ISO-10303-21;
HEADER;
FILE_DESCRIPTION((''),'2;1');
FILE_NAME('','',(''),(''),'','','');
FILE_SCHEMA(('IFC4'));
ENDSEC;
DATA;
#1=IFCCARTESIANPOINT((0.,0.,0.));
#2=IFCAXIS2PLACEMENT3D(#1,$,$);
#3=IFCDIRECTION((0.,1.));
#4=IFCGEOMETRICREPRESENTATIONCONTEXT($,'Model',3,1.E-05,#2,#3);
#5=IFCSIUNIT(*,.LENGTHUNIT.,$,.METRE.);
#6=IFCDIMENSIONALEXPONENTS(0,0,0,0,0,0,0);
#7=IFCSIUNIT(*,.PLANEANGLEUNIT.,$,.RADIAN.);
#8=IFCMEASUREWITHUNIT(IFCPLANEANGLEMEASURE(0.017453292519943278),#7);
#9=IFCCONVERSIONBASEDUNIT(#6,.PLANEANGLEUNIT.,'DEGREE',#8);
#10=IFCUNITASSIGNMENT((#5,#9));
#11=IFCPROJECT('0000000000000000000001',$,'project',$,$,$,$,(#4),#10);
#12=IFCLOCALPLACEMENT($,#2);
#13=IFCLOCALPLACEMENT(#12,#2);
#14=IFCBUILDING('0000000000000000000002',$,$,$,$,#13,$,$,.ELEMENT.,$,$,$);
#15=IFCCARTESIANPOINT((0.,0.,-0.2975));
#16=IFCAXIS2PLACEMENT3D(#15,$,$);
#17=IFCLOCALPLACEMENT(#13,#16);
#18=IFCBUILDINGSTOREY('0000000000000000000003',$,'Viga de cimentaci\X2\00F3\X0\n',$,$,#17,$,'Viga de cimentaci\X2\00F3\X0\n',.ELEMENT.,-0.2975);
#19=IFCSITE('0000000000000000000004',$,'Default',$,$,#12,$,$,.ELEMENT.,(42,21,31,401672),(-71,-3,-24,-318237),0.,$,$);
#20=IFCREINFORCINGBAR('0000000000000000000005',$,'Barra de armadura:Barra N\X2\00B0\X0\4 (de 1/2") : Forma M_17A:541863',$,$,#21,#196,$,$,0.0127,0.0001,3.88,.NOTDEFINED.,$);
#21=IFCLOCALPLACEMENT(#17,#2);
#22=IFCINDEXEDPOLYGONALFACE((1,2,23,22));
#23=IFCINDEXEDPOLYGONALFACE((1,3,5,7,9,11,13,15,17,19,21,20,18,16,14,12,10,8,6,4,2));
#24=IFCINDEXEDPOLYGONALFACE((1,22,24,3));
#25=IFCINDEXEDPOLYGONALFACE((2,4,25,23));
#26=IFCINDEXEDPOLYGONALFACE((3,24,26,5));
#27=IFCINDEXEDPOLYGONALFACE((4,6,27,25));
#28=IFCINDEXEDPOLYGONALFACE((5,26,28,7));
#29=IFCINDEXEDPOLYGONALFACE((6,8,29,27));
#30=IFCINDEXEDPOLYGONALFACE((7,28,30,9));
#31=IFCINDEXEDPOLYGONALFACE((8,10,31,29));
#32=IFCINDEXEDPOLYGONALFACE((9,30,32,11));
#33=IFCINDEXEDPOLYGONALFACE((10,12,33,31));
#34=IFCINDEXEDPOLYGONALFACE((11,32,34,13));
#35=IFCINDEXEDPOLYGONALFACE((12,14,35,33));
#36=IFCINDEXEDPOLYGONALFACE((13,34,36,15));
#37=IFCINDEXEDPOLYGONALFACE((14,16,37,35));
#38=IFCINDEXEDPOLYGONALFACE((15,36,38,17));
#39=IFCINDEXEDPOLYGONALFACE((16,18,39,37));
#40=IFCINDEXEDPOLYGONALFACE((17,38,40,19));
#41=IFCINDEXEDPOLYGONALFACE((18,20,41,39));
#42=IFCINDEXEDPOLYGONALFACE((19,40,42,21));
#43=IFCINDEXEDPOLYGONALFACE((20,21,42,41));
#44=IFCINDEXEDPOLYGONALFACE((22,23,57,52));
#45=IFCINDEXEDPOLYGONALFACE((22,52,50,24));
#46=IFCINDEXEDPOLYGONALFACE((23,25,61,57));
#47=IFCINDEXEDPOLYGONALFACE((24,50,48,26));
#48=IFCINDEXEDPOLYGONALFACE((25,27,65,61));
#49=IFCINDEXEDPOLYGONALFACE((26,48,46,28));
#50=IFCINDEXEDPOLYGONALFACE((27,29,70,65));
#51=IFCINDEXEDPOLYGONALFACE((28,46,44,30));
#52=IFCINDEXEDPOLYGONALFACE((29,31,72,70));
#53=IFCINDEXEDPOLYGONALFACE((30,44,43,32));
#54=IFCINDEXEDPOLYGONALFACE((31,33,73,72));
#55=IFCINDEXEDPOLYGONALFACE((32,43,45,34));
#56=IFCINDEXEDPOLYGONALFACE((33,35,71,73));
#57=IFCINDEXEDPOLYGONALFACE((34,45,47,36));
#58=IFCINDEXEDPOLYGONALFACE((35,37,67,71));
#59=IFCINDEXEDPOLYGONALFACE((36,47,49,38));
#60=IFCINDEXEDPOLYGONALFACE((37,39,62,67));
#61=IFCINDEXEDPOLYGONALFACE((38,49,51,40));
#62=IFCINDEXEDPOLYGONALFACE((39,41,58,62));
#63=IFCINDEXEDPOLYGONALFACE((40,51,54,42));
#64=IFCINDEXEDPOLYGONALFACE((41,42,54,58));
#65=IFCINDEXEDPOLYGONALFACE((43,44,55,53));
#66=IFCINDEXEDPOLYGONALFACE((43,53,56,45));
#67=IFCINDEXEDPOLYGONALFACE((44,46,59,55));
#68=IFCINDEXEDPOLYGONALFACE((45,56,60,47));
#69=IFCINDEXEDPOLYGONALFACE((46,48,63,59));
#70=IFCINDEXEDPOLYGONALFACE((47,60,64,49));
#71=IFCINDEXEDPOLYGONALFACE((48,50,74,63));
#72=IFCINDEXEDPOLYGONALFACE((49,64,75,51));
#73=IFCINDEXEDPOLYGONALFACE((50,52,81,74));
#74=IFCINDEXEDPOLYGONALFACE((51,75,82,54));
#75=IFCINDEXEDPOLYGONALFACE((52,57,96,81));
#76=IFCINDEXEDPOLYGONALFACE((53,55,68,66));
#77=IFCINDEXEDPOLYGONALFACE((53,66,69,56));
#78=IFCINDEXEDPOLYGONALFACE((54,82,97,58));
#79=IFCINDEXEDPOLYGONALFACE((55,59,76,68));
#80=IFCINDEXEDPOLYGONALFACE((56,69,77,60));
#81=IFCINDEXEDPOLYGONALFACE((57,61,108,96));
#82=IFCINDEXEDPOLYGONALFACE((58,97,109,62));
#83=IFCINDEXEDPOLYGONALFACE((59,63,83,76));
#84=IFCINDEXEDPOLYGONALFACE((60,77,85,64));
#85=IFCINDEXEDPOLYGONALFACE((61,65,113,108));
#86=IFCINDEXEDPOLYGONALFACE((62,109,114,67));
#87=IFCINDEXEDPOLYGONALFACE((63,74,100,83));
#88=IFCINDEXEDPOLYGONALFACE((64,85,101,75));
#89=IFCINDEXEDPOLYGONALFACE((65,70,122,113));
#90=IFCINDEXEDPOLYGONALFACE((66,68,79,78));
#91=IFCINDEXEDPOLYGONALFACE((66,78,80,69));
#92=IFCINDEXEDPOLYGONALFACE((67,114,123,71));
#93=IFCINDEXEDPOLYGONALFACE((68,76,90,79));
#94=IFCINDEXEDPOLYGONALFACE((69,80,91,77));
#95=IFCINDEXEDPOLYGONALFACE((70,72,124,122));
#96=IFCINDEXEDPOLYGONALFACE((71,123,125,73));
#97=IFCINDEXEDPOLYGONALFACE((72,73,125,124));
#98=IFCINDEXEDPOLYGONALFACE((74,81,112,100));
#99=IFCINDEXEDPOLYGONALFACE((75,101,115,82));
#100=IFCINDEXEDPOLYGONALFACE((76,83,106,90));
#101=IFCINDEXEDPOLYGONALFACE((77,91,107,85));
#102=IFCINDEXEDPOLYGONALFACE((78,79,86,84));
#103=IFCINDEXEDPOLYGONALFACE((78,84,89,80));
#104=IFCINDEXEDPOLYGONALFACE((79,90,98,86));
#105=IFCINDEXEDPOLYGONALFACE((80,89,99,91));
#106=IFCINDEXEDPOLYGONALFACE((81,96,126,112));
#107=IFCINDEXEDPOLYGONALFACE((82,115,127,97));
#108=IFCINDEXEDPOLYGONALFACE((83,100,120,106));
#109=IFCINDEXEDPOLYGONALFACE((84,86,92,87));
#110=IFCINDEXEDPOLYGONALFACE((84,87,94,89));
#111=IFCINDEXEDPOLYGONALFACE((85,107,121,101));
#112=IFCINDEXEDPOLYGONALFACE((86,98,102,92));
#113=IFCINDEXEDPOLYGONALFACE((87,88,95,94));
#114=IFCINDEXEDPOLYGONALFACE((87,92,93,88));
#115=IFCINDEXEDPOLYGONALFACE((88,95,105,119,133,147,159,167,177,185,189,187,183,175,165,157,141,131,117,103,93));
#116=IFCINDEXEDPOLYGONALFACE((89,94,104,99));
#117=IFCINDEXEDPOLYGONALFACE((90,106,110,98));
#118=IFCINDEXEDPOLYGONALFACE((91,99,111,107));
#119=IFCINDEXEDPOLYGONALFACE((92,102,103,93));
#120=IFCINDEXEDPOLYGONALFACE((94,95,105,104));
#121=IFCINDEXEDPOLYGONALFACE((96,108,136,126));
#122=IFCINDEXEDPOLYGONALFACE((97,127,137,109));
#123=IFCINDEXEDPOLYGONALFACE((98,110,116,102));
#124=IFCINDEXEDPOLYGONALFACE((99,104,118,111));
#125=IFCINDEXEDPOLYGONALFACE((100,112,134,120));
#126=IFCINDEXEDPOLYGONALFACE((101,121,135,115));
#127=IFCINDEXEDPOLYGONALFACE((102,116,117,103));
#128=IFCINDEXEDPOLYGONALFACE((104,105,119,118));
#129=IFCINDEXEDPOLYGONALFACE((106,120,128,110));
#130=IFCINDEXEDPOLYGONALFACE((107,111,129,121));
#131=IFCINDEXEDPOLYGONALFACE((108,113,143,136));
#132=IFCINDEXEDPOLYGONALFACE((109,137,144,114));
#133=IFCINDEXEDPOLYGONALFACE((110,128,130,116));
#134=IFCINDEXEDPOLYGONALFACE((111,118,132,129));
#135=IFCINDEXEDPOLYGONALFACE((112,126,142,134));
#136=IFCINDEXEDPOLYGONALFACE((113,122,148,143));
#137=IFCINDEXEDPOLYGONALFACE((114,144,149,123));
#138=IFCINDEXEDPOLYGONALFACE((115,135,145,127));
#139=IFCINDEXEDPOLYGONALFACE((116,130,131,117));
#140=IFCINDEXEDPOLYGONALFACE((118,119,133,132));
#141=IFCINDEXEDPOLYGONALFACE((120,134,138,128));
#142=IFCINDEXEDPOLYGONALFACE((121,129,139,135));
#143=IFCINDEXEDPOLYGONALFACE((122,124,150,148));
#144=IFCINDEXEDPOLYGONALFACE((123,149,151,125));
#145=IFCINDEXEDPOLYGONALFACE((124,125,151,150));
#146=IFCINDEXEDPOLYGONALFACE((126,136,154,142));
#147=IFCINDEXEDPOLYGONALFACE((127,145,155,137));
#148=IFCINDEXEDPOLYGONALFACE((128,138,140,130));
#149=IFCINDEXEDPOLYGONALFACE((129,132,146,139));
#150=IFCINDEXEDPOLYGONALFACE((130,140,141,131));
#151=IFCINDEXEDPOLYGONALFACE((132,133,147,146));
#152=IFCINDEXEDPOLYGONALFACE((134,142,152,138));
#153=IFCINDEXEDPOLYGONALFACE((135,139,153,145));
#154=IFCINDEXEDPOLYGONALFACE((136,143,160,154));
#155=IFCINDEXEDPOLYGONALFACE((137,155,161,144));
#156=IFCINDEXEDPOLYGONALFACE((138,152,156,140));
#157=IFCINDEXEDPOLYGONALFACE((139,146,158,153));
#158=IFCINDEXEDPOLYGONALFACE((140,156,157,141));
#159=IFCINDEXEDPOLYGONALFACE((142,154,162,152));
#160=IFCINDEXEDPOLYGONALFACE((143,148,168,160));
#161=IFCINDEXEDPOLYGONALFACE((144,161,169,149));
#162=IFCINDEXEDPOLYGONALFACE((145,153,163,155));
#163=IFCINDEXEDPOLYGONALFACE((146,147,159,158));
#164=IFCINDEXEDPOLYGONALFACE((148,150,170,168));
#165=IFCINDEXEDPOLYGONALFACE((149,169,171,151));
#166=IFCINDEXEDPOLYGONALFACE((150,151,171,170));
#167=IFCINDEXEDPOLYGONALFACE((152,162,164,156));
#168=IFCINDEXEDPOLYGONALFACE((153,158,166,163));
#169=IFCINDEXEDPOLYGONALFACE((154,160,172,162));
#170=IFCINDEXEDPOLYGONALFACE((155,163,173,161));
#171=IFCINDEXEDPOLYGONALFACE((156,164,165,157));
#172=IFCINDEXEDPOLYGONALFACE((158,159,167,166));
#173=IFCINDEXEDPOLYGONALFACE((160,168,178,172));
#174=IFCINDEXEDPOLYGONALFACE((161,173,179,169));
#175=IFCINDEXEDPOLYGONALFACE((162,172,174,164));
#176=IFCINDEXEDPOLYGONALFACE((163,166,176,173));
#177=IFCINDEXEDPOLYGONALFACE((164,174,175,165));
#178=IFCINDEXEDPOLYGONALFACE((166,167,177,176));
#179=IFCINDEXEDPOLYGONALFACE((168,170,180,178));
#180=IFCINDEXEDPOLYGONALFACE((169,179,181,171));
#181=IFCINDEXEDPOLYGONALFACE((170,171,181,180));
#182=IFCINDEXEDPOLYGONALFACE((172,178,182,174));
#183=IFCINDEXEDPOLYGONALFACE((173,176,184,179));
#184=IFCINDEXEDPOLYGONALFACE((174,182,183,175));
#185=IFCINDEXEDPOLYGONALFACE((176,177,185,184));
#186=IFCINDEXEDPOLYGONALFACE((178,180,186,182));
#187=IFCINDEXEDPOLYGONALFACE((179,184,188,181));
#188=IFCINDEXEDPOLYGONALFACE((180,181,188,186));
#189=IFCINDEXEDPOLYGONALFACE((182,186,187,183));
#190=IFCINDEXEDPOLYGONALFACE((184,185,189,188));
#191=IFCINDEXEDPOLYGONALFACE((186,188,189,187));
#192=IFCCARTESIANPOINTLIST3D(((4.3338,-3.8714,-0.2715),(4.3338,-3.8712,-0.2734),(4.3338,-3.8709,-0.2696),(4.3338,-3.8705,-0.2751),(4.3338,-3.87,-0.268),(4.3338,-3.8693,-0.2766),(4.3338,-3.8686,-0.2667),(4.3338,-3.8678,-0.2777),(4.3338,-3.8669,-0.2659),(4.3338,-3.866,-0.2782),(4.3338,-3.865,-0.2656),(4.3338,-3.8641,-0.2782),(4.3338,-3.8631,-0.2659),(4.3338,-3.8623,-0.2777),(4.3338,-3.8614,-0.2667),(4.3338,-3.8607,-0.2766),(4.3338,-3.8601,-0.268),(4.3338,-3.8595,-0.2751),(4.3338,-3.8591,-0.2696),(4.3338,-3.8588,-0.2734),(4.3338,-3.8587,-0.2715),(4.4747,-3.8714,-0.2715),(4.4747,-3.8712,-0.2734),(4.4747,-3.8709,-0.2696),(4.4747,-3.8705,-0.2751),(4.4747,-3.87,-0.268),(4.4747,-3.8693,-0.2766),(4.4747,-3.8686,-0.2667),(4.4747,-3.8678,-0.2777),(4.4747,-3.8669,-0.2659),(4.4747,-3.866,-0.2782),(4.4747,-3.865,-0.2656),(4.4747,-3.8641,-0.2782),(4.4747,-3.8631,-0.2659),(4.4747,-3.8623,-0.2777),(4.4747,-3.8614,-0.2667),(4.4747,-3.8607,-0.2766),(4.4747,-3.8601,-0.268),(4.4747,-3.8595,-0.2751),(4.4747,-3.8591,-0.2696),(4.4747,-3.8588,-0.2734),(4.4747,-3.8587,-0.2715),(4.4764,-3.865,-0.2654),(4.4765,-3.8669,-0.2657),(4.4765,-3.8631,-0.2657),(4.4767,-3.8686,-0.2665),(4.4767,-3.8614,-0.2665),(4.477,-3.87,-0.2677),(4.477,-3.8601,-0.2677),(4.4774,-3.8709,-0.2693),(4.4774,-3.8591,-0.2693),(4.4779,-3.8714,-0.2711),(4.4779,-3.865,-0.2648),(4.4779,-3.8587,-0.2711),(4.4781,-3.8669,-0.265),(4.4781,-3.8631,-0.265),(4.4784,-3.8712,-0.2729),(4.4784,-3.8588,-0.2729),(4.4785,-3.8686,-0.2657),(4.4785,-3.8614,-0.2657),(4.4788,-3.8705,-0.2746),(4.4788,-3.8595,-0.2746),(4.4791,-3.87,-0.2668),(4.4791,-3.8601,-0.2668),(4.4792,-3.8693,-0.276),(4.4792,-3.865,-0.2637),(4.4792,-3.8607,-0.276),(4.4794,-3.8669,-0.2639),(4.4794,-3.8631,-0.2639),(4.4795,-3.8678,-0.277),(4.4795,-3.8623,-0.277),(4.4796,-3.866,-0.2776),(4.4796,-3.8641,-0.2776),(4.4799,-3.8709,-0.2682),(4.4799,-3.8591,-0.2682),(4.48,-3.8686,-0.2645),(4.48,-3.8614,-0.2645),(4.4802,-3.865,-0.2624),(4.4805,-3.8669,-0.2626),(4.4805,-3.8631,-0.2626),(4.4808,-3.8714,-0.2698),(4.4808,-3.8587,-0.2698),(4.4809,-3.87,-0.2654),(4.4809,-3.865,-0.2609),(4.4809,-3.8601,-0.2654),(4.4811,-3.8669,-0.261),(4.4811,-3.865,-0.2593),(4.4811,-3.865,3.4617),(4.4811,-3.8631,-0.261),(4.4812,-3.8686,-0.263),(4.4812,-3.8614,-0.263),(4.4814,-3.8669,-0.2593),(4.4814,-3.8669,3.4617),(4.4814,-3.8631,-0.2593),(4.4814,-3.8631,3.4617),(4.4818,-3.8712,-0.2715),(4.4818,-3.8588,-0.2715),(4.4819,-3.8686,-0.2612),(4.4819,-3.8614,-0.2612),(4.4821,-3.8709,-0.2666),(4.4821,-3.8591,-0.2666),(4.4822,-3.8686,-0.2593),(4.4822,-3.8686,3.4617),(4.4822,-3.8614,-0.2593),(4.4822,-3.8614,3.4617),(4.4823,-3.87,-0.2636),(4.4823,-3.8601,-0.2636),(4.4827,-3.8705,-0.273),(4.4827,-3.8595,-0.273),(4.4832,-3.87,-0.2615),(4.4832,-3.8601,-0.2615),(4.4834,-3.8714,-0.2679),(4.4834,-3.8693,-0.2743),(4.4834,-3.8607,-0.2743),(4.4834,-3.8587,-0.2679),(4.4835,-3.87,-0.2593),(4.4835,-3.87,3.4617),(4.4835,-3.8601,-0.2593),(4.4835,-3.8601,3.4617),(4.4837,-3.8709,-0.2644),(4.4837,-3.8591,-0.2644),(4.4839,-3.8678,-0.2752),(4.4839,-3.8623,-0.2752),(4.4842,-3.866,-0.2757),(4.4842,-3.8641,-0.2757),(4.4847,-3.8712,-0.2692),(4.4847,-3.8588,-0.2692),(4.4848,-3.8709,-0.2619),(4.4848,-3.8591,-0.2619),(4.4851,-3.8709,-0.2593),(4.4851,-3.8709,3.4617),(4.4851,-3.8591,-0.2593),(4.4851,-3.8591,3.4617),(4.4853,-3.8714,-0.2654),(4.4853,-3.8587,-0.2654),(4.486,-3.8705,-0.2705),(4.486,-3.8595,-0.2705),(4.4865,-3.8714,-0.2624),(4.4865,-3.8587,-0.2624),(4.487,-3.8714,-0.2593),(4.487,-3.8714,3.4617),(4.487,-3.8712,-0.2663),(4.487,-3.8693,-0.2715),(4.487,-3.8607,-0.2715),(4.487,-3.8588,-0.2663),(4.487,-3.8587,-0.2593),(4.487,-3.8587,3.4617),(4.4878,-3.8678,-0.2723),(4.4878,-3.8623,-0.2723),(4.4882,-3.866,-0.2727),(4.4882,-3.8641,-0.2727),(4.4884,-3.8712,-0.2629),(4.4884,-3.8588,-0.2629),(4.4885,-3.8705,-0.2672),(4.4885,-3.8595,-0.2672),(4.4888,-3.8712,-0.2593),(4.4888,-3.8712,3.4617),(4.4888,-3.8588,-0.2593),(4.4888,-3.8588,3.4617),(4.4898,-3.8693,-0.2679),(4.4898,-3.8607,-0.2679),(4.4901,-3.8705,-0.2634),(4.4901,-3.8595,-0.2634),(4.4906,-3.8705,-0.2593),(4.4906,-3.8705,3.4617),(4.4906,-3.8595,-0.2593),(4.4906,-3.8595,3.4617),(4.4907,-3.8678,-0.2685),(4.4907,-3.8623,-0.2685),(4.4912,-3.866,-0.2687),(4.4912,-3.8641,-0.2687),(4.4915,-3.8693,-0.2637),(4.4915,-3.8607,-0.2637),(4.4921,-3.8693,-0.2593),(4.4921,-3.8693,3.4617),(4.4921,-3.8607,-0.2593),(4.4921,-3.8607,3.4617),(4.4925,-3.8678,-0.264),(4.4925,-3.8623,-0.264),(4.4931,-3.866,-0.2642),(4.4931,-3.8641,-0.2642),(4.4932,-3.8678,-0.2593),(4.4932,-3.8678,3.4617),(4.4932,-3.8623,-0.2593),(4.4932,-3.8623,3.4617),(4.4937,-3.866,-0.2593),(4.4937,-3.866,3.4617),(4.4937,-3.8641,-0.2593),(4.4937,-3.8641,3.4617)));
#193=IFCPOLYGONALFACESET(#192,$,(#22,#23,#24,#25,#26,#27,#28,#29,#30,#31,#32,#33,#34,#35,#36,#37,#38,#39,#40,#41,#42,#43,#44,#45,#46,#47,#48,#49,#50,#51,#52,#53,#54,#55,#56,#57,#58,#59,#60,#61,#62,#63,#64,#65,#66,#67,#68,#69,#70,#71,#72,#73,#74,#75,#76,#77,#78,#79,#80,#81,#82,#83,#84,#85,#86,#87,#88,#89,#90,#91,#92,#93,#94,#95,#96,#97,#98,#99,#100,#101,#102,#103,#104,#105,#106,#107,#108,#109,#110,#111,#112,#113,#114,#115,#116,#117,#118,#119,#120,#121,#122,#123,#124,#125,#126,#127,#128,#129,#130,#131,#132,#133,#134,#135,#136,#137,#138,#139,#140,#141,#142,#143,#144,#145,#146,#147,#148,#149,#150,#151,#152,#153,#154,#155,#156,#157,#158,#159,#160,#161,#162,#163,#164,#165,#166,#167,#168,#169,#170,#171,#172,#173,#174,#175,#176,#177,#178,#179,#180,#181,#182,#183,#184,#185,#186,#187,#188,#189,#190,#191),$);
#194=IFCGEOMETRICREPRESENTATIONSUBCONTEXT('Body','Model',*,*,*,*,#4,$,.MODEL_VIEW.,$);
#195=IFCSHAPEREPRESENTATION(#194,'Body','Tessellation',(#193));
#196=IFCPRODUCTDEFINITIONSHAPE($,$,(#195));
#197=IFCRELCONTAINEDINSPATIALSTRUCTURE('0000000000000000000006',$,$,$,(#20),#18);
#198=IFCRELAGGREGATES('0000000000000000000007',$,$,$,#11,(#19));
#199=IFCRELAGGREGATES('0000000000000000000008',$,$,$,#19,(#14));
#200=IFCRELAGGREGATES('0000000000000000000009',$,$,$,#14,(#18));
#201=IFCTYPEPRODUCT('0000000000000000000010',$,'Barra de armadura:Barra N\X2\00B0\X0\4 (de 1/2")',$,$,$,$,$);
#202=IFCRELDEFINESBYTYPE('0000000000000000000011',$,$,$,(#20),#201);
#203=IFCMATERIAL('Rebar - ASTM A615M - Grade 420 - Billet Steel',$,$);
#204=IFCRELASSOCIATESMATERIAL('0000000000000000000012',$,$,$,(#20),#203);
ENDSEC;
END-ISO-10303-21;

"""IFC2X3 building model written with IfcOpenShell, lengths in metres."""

from ifc_helpers import new_model, entity, si_unit, converted_unit, direction, frame, origin, place, context, subcontext, project, spatial, material, type_object, element, save


model = new_model("IFC2X3")

# Units and contexts
model_context = context("Model", 3, precision=1e-05, world=origin(), true_north=direction((0.0, 1.0)))
body_context = subcontext(model_context, "Body", "Model", "MODEL_VIEW")
ifc_project = project(units=[si_unit("LENGTHUNIT", "METRE"), converted_unit("PLANEANGLEUNIT", "DEGREE", entity("IfcPlaneAngleMeasure", 0.017453292519943278), si_unit("PLANEANGLEUNIT", "RADIAN"), dimensions=[0, 0, 0, 0, 0, 0, 0])], contexts=[model_context])

# Site, building, storey
site_placement = place(None, origin())
site = spatial("IfcSite", under=ifc_project, at=site_placement, Name="Default", CompositionType="ELEMENT", RefLatitude=(42, 21, 31, 401672), RefLongitude=(-71, -3, -24, -318237), RefElevation=0.0)
building_placement = place(site_placement, origin())
building = spatial("IfcBuilding", under=site, at=building_placement, CompositionType="ELEMENT")
storey_placement = place(building_placement, frame((0.0, 0.0, -0.2975)))
storey = spatial("IfcBuildingStorey", under=building, at=storey_placement, Name="Viga de cimentación", LongName="Viga de cimentación", CompositionType="ELEMENT", Elevation=-0.2975)

# Reinforcing bar
ifc_material_1 = material(Name="Rebar - ASTM A615M - Grade 420 - Billet Steel")
type_product_1 = type_object("IfcTypeProduct", Name="Barra de armadura:Barra N°4 (de 1/2\")")
reinforcing_bar_1_placement = place(storey_placement, origin())
element("IfcReinforcingBar", 1, at=reinforcing_bar_1_placement, inside=storey, type_object=type_product_1, material=ifc_material_1, Name="Barra de armadura:Barra N°4 (de 1/2\") : Forma M_17A:541863", BarLength=3.88, BarRole="NOTDEFINED", CrossSectionArea=0.0001, NominalDiameter=0.0127, context=body_context, shape_type="AdvancedSweptSolid", body=[
    entity("IfcSweptDiskSolid", entity("IfcCompositeCurve", [entity("IfcCompositeCurveSegment", "CONTINUOUS", True, entity("IfcPolyline", [entity("IfcCartesianPoint", [4.4874, -3.865, 3.4617]), entity("IfcCartesianPoint", [4.4874, -3.865, -0.2593])])), entity("IfcCompositeCurveSegment", "CONTINUOUS", True, entity("IfcTrimmedCurve", entity("IfcCircle", entity("IfcAxis2Placement3D", entity("IfcCartesianPoint", [4.4747, -3.865, -0.2593]), entity("IfcDirection", [0.0, 1.0, 0.0]), entity("IfcDirection", [0.0, 0.0, -1.0])), 0.0127), [entity("IfcParameterValue", 270.0)], [entity("IfcParameterValue", 360.0)], True, "PARAMETER")), entity("IfcCompositeCurveSegment", "CONTINUOUS", True, entity("IfcPolyline", [entity("IfcCartesianPoint", [4.4747, -3.865, -0.272]), entity("IfcCartesianPoint", [4.3338, -3.865, -0.272])]))], False), 0.0063, None, 0.0, 92.0),
])

save(model, "model.ifc")
